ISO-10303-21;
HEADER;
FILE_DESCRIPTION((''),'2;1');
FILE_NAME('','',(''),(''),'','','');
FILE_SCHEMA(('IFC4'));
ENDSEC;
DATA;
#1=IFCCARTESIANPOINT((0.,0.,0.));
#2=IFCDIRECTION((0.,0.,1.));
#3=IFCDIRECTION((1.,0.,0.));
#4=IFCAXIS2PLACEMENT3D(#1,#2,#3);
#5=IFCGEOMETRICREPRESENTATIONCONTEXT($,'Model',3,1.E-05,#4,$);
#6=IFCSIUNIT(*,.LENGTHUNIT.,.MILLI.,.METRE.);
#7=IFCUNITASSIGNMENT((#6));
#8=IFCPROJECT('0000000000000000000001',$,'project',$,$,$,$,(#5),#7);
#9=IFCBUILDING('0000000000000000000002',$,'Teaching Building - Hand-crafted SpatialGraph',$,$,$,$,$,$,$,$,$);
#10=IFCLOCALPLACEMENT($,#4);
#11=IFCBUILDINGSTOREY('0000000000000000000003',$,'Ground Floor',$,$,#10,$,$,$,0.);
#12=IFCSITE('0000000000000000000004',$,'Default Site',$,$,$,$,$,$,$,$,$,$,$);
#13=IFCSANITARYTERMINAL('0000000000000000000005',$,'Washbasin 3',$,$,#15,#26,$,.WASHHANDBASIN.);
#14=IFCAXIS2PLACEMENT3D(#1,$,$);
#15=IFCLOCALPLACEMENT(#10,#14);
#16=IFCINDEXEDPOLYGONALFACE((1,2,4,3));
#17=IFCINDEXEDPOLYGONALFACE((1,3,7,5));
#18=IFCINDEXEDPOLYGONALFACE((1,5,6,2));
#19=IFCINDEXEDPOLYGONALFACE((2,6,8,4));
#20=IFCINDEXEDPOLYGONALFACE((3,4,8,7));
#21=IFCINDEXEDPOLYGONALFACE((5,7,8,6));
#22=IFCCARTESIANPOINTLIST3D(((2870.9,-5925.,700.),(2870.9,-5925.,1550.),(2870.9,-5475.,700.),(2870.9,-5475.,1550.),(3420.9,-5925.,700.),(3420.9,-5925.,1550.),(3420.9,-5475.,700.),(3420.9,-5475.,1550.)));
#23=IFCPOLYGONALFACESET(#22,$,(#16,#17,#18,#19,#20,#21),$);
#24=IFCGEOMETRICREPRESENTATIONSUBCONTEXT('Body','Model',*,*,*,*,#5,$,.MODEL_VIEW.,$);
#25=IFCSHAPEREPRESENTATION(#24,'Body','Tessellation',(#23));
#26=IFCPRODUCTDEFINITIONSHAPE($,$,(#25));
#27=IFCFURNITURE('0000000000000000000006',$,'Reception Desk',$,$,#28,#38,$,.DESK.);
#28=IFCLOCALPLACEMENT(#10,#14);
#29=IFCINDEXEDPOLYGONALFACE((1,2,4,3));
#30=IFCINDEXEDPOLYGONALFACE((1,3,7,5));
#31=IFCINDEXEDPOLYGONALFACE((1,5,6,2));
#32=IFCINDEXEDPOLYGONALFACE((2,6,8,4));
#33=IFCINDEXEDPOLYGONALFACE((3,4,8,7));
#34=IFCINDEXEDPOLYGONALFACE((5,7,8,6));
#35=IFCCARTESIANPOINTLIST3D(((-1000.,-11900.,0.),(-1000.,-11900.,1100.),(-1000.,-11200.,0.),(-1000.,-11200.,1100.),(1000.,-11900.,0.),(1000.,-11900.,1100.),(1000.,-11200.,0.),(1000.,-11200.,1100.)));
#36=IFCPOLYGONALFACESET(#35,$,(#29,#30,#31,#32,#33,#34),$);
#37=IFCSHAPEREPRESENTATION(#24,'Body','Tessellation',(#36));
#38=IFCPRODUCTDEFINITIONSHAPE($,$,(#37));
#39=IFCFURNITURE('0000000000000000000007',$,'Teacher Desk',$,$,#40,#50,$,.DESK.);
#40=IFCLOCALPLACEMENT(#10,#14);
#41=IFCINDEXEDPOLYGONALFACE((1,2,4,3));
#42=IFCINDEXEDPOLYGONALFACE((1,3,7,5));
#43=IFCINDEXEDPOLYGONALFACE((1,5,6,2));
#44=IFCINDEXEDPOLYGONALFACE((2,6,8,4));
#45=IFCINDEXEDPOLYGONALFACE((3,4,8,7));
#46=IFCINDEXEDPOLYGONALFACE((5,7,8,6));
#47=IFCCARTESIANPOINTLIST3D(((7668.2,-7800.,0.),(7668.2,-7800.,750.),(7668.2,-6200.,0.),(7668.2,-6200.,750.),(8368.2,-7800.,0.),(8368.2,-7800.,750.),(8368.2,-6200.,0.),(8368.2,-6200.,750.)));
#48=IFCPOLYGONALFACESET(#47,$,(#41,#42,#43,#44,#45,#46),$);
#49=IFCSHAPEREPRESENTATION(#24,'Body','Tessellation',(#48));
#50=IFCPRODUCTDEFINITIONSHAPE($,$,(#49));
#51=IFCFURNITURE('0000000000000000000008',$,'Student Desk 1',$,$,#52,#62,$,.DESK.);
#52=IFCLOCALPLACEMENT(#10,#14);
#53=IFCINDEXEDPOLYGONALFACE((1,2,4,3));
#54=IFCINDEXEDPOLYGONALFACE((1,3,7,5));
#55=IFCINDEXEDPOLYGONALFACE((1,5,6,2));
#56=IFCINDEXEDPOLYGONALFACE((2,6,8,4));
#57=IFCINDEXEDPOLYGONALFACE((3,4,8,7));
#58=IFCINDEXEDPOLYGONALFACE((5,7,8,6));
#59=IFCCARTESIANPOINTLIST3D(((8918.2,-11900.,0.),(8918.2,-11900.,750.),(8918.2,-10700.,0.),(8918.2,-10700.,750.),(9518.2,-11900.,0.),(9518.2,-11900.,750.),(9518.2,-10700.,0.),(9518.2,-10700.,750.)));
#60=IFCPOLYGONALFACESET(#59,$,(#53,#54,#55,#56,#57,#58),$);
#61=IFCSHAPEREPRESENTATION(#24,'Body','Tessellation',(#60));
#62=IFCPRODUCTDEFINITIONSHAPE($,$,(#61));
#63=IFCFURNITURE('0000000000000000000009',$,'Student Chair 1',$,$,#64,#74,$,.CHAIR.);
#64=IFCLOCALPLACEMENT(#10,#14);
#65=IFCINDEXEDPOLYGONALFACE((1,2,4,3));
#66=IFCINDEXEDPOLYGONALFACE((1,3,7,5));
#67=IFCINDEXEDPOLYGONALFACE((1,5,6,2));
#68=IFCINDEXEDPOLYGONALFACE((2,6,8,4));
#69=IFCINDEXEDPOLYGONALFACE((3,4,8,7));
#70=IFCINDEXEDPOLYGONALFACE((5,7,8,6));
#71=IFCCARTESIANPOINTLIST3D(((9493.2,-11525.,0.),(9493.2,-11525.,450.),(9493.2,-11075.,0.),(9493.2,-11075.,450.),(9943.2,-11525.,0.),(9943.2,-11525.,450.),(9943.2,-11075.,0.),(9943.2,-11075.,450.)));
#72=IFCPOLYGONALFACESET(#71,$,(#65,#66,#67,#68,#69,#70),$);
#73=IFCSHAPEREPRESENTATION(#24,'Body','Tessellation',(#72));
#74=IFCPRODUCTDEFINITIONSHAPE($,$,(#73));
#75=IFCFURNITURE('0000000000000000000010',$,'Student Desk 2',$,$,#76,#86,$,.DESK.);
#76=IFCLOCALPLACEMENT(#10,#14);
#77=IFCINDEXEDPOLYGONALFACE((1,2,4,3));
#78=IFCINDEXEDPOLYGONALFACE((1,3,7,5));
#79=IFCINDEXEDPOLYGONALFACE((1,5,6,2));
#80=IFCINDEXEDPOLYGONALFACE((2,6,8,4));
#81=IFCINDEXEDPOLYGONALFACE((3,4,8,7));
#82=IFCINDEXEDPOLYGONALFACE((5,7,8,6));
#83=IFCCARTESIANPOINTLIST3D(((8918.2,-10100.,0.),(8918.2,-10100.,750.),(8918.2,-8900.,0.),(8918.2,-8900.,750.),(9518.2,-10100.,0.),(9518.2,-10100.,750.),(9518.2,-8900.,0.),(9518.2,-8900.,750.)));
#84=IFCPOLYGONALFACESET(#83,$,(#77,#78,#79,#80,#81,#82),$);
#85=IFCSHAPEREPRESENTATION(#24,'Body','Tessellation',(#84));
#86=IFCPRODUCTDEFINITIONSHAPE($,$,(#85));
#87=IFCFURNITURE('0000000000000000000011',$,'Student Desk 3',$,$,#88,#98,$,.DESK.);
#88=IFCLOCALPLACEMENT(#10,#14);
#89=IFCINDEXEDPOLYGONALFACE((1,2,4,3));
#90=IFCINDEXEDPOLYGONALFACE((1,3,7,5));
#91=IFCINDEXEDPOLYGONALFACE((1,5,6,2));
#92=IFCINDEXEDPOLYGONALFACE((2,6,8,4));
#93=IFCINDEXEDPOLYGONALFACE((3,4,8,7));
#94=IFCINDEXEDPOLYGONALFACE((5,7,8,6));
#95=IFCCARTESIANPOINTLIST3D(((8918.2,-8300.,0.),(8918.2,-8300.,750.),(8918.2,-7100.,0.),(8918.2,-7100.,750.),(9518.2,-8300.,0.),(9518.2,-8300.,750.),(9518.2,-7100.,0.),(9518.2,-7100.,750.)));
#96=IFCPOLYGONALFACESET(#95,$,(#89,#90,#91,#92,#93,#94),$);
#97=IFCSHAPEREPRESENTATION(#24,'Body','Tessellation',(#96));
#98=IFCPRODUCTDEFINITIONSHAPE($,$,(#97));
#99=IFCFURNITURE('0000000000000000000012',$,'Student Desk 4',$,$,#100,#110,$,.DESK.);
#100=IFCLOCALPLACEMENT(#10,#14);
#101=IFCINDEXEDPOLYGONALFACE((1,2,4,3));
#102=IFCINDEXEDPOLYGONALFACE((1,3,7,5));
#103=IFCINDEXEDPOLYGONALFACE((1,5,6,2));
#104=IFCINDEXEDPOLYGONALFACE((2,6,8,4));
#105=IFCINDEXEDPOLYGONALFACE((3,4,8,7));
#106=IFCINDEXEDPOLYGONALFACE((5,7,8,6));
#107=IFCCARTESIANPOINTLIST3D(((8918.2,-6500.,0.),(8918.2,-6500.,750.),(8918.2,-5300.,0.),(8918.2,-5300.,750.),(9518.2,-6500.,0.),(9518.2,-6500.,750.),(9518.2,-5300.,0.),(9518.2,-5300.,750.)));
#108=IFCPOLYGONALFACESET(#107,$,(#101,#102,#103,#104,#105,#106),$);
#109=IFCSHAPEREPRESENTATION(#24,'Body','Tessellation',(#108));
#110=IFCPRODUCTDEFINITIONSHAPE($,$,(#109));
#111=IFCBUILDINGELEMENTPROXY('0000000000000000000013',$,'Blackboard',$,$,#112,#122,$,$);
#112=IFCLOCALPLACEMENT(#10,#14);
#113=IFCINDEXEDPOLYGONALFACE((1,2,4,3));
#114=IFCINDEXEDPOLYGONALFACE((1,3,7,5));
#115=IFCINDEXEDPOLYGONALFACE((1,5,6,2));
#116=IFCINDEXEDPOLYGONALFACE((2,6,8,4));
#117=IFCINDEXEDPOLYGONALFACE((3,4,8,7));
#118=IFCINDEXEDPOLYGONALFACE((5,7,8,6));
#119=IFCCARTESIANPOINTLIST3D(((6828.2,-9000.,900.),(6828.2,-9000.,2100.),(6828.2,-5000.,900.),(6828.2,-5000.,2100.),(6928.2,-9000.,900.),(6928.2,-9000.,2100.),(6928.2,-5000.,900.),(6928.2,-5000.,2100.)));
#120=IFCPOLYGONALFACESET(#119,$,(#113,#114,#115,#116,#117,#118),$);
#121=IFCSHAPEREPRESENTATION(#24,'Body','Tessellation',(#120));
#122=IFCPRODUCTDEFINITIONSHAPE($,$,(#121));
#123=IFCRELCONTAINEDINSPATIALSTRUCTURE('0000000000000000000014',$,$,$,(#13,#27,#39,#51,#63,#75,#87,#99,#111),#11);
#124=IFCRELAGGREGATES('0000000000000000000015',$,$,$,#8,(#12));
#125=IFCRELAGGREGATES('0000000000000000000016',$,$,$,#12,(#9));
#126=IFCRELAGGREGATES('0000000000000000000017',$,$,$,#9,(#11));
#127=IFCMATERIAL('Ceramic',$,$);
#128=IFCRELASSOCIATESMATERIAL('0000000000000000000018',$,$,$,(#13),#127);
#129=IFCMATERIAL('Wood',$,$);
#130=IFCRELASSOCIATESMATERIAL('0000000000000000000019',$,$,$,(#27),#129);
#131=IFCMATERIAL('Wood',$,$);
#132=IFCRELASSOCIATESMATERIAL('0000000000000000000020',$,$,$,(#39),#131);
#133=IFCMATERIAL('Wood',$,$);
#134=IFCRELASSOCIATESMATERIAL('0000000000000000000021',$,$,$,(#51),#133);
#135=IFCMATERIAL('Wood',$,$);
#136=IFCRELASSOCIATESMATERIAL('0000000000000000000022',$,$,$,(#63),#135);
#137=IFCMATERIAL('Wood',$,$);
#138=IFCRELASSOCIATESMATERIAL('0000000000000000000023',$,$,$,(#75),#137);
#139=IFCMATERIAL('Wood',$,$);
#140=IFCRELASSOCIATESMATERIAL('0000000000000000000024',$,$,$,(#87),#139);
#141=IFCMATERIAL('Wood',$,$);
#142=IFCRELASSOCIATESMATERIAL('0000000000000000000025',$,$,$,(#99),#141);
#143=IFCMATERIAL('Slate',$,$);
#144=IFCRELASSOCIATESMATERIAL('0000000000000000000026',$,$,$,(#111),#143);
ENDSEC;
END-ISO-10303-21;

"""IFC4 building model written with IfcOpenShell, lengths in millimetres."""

from ifc_helpers import new_model, si_unit, frame, origin_with_axes, origin_2d, place, context, subcontext, project, spatial, rectangle, extrude, material, element, save


model = new_model("IFC4")

# Units and contexts
model_context = context("Model", 3, precision=1e-05, world=origin_with_axes())
body_context = subcontext(model_context, "Body", "Model", "MODEL_VIEW")
ifc_project = project(units=[si_unit("LENGTHUNIT", "METRE", prefix="MILLI")], contexts=[model_context])

# Site, building, storey
site = spatial("IfcSite", under=ifc_project, Name="Default Site")
building = spatial("IfcBuilding", under=site, Name="Teaching Building - Hand-crafted SpatialGraph")
storey_placement = place(None, origin_with_axes())
storey = spatial("IfcBuildingStorey", under=building, at=storey_placement, Name="Ground Floor", Elevation=0.0)

# Sanitary terminal
ifc_material_1 = material(Name="Ceramic")
sanitary_terminal_1_placement = place(storey_placement, frame((3145.9, -5700.0, 700.0), z_axis=(0.0, 0.0, 1.0), x_axis=(0.0, 1.0, 0.0)))
element("IfcSanitaryTerminal", 1, at=sanitary_terminal_1_placement, inside=storey, material=ifc_material_1, Name="Washbasin 3", PredefinedType="WASHHANDBASIN", context=body_context, shape_type="SweptSolid", body=[
    extrude(rectangle(XDim=450.0, YDim=550.0, at=origin_2d()), origin_with_axes(), (0.0, 0.0, 1.0), 850.0),
])

# Furniture
ifc_material_2 = material(Name="Wood")
furniture_1_placement = place(storey_placement, frame((0.0, -11550.0, 0.0), z_axis=(0.0, 0.0, 1.0), x_axis=(1.0, 0.0, 0.0)))
element("IfcFurniture", 2, at=furniture_1_placement, inside=storey, material=ifc_material_2, Name="Reception Desk", PredefinedType="DESK", context=body_context, shape_type="SweptSolid", body=[
    extrude(rectangle(XDim=2000.0, YDim=700.0, at=origin_2d()), origin_with_axes(), (0.0, 0.0, 1.0), 1100.0),
])
ifc_material_3 = material(Name="Wood")
furniture_2_placement = place(storey_placement, frame((8018.2, -7000.0, 0.0), z_axis=(0.0, 0.0, 1.0), x_axis=(0.0, 1.0, 0.0)))
element("IfcFurniture", 3, at=furniture_2_placement, inside=storey, material=ifc_material_3, Name="Teacher Desk", PredefinedType="DESK", context=body_context, shape_type="SweptSolid", body=[
    extrude(rectangle(XDim=1600.0, YDim=700.0, at=origin_2d()), origin_with_axes(), (0.0, 0.0, 1.0), 750.0),
])
ifc_material_4 = material(Name="Wood")
furniture_3_placement = place(storey_placement, frame((9218.2, -11300.0, 0.0), z_axis=(0.0, 0.0, 1.0), x_axis=(0.0, 1.0, 0.0)))
element("IfcFurniture", 4, at=furniture_3_placement, inside=storey, material=ifc_material_4, Name="Student Desk 1", PredefinedType="DESK", context=body_context, shape_type="SweptSolid", body=[
    extrude(rectangle(XDim=1200.0, YDim=600.0, at=origin_2d()), origin_with_axes(), (0.0, 0.0, 1.0), 750.0),
])
ifc_material_5 = material(Name="Wood")
furniture_4_placement = place(storey_placement, frame((9718.2, -11300.0, 0.0), z_axis=(0.0, 0.0, 1.0), x_axis=(1.0, 0.0, 0.0)))
element("IfcFurniture", 5, at=furniture_4_placement, inside=storey, material=ifc_material_5, Name="Student Chair 1", PredefinedType="CHAIR", context=body_context, shape_type="SweptSolid", body=[
    extrude(rectangle(XDim=450.0, YDim=450.0, at=origin_2d()), origin_with_axes(), (0.0, 0.0, 1.0), 450.0),
])
ifc_material_6 = material(Name="Wood")
furniture_5_placement = place(storey_placement, frame((9218.2, -9500.0, 0.0), z_axis=(0.0, 0.0, 1.0), x_axis=(0.0, 1.0, 0.0)))
element("IfcFurniture", 6, at=furniture_5_placement, inside=storey, material=ifc_material_6, Name="Student Desk 2", PredefinedType="DESK", context=body_context, shape_type="SweptSolid", body=[
    extrude(rectangle(XDim=1200.0, YDim=600.0, at=origin_2d()), origin_with_axes(), (0.0, 0.0, 1.0), 750.0),
])
ifc_material_7 = material(Name="Wood")
furniture_6_placement = place(storey_placement, frame((9218.2, -7700.0, 0.0), z_axis=(0.0, 0.0, 1.0), x_axis=(0.0, 1.0, 0.0)))
element("IfcFurniture", 7, at=furniture_6_placement, inside=storey, material=ifc_material_7, Name="Student Desk 3", PredefinedType="DESK", context=body_context, shape_type="SweptSolid", body=[
    extrude(rectangle(XDim=1200.0, YDim=600.0, at=origin_2d()), origin_with_axes(), (0.0, 0.0, 1.0), 750.0),
])
ifc_material_8 = material(Name="Wood")
furniture_7_placement = place(storey_placement, frame((9218.2, -5900.0, 0.0), z_axis=(0.0, 0.0, 1.0), x_axis=(0.0, 1.0, 0.0)))
element("IfcFurniture", 8, at=furniture_7_placement, inside=storey, material=ifc_material_8, Name="Student Desk 4", PredefinedType="DESK", context=body_context, shape_type="SweptSolid", body=[
    extrude(rectangle(XDim=1200.0, YDim=600.0, at=origin_2d()), origin_with_axes(), (0.0, 0.0, 1.0), 750.0),
])

# Building element proxy
ifc_material_9 = material(Name="Slate")
proxy_placement = place(storey_placement, frame((6878.2, -7000.0, 900.0), z_axis=(0.0, 0.0, 1.0), x_axis=(1.0, 0.0, 0.0)))
element("IfcBuildingElementProxy", 9, at=proxy_placement, inside=storey, material=ifc_material_9, Name="Blackboard", context=body_context, shape_type="SweptSolid", body=[
    extrude(rectangle(XDim=100.0, YDim=4000.0, at=origin_2d()), origin_with_axes(), (0.0, 0.0, 1.0), 1200.0),
])

save(model, "model.ifc")
